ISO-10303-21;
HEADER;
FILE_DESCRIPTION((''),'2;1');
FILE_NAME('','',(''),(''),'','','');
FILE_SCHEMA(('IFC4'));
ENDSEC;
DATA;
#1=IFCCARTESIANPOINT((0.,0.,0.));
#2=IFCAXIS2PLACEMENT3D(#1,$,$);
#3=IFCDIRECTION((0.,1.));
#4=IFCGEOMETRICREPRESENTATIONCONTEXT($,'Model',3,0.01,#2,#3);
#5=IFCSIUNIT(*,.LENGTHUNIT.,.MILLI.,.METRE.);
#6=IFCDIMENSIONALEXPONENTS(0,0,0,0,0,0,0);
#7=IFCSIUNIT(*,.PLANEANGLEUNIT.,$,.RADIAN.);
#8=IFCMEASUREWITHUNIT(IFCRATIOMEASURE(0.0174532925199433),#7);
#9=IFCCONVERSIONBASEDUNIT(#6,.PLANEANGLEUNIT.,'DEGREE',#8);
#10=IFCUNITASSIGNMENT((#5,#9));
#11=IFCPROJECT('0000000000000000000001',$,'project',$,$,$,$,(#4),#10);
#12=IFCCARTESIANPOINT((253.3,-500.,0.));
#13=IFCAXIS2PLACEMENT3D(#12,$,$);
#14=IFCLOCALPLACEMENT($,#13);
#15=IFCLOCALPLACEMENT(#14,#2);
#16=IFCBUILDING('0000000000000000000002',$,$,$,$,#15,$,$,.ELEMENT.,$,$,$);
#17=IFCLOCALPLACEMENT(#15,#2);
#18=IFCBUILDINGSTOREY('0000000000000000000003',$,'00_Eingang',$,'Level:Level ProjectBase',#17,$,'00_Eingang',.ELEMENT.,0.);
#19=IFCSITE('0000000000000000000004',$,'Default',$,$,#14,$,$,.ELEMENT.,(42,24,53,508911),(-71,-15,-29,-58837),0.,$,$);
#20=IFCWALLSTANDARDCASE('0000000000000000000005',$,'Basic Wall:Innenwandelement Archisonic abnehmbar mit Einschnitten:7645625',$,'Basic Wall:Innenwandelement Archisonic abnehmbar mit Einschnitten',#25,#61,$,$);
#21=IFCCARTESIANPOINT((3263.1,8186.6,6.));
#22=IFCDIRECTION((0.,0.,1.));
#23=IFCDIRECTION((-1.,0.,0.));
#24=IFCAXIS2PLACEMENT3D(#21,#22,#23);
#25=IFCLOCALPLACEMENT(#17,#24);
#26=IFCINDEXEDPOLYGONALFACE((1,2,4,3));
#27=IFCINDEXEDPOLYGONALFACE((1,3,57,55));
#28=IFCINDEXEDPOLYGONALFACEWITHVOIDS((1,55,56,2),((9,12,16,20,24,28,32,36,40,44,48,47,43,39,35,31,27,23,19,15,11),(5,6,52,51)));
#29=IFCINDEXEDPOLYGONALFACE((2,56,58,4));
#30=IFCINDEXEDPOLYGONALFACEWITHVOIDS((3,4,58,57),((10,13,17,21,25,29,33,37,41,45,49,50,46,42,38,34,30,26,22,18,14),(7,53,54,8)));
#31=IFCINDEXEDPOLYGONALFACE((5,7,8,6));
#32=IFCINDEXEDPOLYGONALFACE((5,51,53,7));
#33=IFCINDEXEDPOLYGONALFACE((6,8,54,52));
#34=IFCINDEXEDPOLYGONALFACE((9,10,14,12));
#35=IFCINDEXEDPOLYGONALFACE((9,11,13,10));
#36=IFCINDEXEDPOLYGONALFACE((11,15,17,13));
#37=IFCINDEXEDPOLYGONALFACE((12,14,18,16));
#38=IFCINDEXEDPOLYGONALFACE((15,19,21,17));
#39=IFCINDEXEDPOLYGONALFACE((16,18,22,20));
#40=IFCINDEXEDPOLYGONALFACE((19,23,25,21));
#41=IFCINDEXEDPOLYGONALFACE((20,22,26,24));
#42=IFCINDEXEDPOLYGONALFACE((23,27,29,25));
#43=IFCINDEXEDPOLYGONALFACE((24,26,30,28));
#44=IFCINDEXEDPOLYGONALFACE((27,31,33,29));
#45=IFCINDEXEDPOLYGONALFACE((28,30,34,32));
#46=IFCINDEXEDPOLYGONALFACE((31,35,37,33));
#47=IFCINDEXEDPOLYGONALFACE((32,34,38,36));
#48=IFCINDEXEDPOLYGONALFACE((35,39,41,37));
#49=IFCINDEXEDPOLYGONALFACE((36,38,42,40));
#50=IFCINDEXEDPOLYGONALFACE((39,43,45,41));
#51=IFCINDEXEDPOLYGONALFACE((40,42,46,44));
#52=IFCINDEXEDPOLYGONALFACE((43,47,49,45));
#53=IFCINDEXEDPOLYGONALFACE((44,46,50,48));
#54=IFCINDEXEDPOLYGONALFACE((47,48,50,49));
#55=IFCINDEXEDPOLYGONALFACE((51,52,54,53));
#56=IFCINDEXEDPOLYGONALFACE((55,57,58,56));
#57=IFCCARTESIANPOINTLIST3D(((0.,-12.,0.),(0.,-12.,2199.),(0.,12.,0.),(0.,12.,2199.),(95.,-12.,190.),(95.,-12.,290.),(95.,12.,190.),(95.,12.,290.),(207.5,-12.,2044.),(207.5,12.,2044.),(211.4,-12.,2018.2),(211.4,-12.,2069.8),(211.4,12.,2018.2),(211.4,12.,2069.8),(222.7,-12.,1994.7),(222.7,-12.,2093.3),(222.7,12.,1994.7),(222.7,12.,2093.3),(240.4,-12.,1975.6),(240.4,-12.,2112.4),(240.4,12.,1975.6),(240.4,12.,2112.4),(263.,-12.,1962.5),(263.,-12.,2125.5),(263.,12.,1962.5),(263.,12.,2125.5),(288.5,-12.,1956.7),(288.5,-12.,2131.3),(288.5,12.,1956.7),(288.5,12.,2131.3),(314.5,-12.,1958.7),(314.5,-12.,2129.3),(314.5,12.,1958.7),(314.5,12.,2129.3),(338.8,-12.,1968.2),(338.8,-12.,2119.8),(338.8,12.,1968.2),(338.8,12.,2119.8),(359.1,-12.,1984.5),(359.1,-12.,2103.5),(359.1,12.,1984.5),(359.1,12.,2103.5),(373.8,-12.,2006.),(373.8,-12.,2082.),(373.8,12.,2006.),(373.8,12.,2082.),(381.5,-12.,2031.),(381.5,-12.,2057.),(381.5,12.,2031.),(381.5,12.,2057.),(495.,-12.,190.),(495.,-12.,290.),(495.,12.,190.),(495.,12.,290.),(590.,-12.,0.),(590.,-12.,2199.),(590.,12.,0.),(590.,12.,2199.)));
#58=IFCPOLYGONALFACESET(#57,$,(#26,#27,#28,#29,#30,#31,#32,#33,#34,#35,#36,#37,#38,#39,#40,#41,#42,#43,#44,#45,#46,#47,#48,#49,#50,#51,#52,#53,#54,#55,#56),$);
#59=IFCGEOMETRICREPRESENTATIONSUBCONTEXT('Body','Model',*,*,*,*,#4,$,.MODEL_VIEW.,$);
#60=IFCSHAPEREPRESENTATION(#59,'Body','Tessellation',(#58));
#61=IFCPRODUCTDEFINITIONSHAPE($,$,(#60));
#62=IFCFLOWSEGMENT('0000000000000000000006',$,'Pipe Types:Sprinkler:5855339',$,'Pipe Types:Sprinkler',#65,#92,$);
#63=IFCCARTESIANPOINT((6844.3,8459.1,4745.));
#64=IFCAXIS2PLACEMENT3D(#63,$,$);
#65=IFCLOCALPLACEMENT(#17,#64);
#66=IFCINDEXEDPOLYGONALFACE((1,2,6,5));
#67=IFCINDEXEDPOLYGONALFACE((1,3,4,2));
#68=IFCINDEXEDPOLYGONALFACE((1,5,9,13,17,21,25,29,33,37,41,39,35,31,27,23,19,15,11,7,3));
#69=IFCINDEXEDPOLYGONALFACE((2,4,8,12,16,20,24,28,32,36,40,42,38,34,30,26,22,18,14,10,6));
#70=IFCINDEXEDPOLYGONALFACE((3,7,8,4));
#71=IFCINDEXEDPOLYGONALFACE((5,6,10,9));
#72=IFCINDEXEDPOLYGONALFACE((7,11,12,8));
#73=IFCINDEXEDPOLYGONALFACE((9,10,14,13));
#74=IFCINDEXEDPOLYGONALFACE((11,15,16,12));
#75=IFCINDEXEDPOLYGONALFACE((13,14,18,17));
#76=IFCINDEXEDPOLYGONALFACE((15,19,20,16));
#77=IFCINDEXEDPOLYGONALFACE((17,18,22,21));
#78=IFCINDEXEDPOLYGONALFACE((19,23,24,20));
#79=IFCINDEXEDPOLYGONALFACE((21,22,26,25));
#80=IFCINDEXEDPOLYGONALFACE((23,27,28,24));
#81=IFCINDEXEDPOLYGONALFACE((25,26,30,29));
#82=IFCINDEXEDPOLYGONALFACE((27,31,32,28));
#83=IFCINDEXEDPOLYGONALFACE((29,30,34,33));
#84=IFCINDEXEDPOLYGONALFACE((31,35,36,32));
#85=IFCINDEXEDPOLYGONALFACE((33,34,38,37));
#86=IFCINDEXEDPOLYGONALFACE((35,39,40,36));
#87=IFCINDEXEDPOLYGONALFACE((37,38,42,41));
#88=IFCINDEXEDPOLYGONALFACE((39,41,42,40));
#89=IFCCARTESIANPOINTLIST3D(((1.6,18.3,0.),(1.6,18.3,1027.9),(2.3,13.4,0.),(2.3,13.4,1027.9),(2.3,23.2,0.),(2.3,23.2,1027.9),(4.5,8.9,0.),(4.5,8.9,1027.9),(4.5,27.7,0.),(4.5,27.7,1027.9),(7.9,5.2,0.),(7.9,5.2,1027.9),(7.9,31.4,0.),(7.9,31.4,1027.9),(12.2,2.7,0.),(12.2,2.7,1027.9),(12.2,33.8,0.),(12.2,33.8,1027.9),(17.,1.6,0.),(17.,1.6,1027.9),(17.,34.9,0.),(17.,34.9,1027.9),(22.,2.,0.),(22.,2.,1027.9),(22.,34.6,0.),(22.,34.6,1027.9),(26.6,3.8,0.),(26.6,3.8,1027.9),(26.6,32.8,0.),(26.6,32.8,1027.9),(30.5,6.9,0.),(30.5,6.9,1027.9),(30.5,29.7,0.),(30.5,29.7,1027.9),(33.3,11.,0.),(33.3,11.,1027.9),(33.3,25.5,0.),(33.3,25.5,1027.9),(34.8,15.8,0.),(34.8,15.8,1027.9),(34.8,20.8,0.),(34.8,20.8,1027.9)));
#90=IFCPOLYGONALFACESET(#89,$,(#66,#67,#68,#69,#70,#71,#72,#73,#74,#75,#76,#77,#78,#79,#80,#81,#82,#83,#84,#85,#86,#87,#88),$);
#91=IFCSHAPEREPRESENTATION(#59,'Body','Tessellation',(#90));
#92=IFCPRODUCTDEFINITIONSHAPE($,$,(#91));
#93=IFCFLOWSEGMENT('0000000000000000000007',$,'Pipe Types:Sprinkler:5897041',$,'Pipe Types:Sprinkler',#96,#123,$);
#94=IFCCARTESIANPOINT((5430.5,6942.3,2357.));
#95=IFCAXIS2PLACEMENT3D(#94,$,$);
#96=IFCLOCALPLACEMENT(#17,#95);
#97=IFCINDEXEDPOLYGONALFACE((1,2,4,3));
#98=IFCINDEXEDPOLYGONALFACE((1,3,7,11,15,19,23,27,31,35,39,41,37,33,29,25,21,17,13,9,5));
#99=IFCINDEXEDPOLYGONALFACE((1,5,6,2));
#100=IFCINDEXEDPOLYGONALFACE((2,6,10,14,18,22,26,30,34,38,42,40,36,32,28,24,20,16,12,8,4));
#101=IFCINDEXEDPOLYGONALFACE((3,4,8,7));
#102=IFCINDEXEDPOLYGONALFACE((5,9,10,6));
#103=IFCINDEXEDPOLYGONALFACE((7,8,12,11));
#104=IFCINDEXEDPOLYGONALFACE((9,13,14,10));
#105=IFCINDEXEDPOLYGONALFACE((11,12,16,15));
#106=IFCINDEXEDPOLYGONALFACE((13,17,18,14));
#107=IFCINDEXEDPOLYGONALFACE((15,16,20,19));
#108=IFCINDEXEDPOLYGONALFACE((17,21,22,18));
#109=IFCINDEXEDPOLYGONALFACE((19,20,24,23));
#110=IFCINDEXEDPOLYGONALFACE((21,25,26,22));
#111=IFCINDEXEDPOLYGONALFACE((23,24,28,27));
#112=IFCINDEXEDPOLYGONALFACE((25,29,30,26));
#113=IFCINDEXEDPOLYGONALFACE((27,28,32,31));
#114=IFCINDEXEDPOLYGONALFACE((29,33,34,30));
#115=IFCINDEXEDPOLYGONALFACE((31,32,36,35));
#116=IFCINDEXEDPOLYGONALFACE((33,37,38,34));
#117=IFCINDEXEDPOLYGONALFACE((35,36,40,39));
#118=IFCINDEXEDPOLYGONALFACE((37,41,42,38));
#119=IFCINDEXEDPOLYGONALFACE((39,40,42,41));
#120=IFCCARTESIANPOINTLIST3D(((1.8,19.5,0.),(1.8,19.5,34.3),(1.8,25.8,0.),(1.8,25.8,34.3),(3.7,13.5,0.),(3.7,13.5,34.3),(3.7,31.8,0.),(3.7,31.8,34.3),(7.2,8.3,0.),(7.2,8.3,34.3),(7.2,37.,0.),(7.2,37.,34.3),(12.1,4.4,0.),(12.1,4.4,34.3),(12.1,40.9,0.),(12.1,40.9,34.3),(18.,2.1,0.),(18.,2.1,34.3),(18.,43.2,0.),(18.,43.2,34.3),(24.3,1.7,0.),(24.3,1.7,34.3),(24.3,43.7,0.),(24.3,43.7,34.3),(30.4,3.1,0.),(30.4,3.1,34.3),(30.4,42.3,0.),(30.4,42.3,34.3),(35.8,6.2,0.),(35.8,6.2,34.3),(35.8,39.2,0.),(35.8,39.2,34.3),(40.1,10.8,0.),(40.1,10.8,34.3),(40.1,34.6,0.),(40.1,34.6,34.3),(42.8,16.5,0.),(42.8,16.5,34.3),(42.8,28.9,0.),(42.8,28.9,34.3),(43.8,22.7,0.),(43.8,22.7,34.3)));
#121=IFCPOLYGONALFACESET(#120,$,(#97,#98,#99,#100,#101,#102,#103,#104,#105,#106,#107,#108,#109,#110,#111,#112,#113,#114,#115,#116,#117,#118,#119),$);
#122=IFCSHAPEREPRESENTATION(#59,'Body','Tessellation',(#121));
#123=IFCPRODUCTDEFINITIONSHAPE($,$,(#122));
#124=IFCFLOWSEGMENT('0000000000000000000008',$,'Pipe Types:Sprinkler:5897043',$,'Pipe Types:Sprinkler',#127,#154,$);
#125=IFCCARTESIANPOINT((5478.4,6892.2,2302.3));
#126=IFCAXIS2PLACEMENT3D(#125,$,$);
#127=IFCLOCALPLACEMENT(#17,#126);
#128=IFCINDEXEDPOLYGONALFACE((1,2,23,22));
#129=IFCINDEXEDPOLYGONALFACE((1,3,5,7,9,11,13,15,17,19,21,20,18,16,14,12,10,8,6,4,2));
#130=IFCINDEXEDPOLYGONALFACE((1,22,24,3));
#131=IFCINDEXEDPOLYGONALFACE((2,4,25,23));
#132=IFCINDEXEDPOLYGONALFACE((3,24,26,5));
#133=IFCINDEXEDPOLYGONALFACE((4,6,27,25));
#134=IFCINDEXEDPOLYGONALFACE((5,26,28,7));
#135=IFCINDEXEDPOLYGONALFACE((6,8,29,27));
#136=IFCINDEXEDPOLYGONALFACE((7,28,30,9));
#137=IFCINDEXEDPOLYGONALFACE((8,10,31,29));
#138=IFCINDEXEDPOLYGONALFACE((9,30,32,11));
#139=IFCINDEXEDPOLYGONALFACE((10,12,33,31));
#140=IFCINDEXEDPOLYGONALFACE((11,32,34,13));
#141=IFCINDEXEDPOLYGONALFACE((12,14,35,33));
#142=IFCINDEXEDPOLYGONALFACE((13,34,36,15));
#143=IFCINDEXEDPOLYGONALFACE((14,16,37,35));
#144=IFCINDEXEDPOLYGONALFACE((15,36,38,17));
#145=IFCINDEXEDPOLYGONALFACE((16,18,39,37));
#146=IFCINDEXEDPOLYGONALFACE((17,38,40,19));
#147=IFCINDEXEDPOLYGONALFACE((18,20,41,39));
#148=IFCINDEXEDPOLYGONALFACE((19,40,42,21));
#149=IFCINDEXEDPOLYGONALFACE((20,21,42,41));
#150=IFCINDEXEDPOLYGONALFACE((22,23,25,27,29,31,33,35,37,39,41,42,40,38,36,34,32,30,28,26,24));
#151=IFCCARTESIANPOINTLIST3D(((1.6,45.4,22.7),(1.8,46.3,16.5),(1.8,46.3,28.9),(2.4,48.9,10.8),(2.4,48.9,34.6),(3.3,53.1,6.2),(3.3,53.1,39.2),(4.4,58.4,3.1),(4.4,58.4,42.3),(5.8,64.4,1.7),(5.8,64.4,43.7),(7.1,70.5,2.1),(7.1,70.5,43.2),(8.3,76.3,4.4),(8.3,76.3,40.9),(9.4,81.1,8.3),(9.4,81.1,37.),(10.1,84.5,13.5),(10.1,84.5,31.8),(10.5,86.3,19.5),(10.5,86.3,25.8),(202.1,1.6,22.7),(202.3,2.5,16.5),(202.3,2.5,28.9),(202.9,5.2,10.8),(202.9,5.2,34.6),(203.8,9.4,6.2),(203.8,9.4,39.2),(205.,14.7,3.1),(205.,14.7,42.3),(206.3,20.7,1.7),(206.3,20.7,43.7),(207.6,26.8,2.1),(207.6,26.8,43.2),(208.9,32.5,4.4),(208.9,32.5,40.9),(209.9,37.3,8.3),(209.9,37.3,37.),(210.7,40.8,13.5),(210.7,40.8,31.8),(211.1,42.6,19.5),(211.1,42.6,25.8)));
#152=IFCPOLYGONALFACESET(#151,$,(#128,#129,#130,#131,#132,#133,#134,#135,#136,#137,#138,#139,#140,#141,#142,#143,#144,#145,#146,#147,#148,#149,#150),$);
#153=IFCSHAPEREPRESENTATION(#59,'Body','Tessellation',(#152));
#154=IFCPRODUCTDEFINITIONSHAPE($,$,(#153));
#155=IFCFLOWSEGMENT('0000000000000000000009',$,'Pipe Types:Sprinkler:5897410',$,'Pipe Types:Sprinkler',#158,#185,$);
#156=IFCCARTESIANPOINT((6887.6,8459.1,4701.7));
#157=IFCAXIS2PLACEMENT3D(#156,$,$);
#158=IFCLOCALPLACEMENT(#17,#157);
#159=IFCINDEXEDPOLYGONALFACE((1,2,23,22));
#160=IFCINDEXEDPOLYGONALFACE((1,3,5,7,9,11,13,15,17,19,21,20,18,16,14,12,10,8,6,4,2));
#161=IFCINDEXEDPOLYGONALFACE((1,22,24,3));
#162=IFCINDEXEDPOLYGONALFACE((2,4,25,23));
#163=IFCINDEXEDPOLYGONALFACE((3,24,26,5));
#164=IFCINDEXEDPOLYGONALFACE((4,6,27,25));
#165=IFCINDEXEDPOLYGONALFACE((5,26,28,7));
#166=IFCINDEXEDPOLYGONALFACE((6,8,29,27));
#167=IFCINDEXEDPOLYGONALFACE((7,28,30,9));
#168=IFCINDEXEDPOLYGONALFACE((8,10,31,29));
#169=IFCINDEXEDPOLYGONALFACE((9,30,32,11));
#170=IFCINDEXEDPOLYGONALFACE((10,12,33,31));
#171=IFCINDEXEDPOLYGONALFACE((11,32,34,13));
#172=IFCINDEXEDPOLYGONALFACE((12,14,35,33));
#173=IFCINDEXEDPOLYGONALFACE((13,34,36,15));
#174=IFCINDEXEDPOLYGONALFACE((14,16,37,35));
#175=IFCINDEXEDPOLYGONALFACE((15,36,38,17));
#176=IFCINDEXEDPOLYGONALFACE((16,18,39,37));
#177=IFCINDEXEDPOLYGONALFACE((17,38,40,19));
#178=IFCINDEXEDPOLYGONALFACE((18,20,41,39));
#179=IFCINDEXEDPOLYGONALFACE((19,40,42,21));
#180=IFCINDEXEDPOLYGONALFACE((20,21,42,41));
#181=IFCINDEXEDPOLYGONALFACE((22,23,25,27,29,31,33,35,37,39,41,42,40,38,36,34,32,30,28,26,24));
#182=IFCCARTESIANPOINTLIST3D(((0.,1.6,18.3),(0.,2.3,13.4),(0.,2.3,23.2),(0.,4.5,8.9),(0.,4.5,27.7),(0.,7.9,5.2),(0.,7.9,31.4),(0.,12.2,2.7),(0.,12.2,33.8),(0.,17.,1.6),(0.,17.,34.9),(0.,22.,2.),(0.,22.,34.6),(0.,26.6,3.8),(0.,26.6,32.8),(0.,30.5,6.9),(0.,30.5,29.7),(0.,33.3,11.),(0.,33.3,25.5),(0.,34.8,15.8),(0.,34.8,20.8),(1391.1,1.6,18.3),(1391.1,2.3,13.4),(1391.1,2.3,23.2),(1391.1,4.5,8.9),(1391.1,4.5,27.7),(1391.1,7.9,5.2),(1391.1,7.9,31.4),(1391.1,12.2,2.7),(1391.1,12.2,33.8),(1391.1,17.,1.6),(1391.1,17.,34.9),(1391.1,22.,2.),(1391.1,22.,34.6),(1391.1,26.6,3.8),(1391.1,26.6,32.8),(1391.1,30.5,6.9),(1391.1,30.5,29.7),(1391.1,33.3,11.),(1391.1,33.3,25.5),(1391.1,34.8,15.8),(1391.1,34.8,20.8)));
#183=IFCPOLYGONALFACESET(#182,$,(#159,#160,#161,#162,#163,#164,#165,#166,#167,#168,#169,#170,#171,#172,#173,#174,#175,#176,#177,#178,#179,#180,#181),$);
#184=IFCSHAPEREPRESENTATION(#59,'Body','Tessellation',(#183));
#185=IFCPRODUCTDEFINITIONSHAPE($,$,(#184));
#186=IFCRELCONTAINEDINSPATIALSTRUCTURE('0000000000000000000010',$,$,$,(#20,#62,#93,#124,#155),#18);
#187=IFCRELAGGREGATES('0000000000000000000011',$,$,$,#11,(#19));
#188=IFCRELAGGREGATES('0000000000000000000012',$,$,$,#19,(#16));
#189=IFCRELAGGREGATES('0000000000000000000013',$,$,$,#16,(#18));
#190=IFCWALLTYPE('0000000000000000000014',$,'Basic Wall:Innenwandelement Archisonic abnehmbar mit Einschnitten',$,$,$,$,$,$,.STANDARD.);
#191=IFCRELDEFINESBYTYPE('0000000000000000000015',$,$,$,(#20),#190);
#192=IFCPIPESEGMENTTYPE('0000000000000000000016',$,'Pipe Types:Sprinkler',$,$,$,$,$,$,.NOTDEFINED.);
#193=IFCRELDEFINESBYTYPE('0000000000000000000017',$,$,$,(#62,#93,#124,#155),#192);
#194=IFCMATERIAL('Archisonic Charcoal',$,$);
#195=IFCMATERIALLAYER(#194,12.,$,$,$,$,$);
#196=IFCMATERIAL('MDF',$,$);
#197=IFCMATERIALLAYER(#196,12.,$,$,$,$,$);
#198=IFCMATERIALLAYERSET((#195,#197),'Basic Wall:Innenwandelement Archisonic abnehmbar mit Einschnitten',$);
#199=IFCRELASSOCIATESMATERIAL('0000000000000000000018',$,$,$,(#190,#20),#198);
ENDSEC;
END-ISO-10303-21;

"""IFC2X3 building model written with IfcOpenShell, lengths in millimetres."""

from ifc_helpers import new_model, entity, si_unit, converted_unit, direction, frame, frame_2d, origin, origin_2d_with_axis, place, context, subcontext, project, spatial, rectangle, circle, extrude, material, layer, layer_set, layer_usage, type_object, element, save


model = new_model("IFC2X3")

# Units and contexts
model_context = context("Model", 3, precision=0.01, world=origin(), true_north=direction((0.0, 1.0)))
body_context = subcontext(model_context, "Body", "Model", "MODEL_VIEW")
ifc_project = project(units=[si_unit("LENGTHUNIT", "METRE", prefix="MILLI"), converted_unit("PLANEANGLEUNIT", "DEGREE", entity("IfcRatioMeasure", 0.0174532925199433), si_unit("PLANEANGLEUNIT", "RADIAN"), dimensions=[0, 0, 0, 0, 0, 0, 0])], contexts=[model_context])

# Site, building, storey
site_placement = place(None, frame((253.3, -500.0, 0.0)))
site = spatial("IfcSite", under=ifc_project, at=site_placement, Name="Default", CompositionType="ELEMENT", RefLatitude=(42, 24, 53, 508911), RefLongitude=(-71, -15, -29, -58837), RefElevation=0.0)
building_placement = place(site_placement, origin())
building = spatial("IfcBuilding", under=site, at=building_placement, CompositionType="ELEMENT")
storey_placement = place(building_placement, origin())
storey = spatial("IfcBuildingStorey", under=building, at=storey_placement, Name="00_Eingang", ObjectType="Level:Level ProjectBase", LongName="00_Eingang", CompositionType="ELEMENT", Elevation=0.0)

# Shared definitions
ifc_material_1 = material(Name="Archisonic Charcoal")
ifc_material_2 = material(Name="MDF")

# Wall, openings
ifc_layer_1 = layer(ifc_material_1, 12.0)
ifc_layer_2 = layer(ifc_material_2, 12.0)
ifc_layer_set_1 = layer_set([ifc_layer_1, ifc_layer_2], Name="Basic Wall:Innenwandelement Archisonic abnehmbar mit Einschnitten")
ifc_layer_usage_1 = layer_usage(ifc_layer_set_1, "AXIS2", "NEGATIVE", 12.0)
wall_type_1 = type_object("IfcWallType", Name="Basic Wall:Innenwandelement Archisonic abnehmbar mit Einschnitten", PredefinedType="STANDARD", material=ifc_layer_set_1)
wall_1_placement = place(storey_placement, frame((3263.1, 8186.6, 6.0), z_axis=(0.0, 0.0, 1.0), x_axis=(-1.0, 0.0, 0.0)))
wall_1 = element("IfcWallStandardCase", 1, at=wall_1_placement, inside=storey, type_object=wall_type_1, material=ifc_layer_usage_1, Name="Basic Wall:Innenwandelement Archisonic abnehmbar mit Einschnitten:7645625", ObjectType="Basic Wall:Innenwandelement Archisonic abnehmbar mit Einschnitten", context=body_context, shape_type="SweptSolid", body=[
    extrude(rectangle(XDim=590.0, YDim=24.0, at=frame_2d((295.0, 0.0), x_axis=(-1.0, 0.0))), origin(), (0.0, 0.0, 1.0), 2199.0),
])
opening_1_placement = place(wall_1_placement, frame((384.1, 46.7, 1954.9)))
element("IfcOpeningElement", 2, at=opening_1_placement, cuts=wall_1, ObjectType="Opening", context=body_context, shape_type="SweptSolid", body=[
    extrude(circle(Radius=87.5, at=origin_2d_with_axis()), frame((-89.1, -336.7, 89.1), z_axis=(0.0, 1.0, 0.0), x_axis=(-1.0, 0.0, 0.0)), (0.0, 0.0, 1.0), 336.7),
])
opening_2_placement = place(wall_1_placement, frame((495.0, 70.0, 190.0)))
element("IfcOpeningElement", 3, at=opening_2_placement, cuts=wall_1, ObjectType="Opening", context=body_context, shape_type="SweptSolid", body=[
    extrude(rectangle(XDim=100.0, YDim=400.0, at=frame_2d((0.0, 0.0), x_axis=(0.0, 1.0))), frame((-200.0, -200.0, 50.0), z_axis=(0.0, 1.0, 0.0), x_axis=(-1.0, 0.0, 0.0)), (0.0, 0.0, 1.0), 200.0),
])

# Flow segments
pipe_segment_type = type_object("IfcPipeSegmentType", Name="Pipe Types:Sprinkler", PredefinedType="NOTDEFINED")
flow_segment_1_placement = place(storey_placement, frame((6844.3, 8459.1, 4745.0)))
element("IfcFlowSegment", 4, at=flow_segment_1_placement, inside=storey, type_object=pipe_segment_type, Name="Pipe Types:Sprinkler:5855339", ObjectType="Pipe Types:Sprinkler", context=body_context, shape_type="SweptSolid", body=[
    extrude(circle(Radius=16.7, at=origin_2d_with_axis()), frame((18.3, 18.3, 0.0), z_axis=(0.0, 0.0, 1.0), x_axis=(-1.0, 0.0, 0.0)), (0.0, 0.0, 1.0), 1027.9),
])
flow_segment_2_placement = place(storey_placement, frame((5430.5, 6942.3, 2357.0)))
element("IfcFlowSegment", 5, at=flow_segment_2_placement, inside=storey, type_object=pipe_segment_type, Name="Pipe Types:Sprinkler:5897041", ObjectType="Pipe Types:Sprinkler", context=body_context, shape_type="SweptSolid", body=[
    extrude(circle(Radius=21.1, at=origin_2d_with_axis()), frame((22.7, 22.7, 0.0)), (0.0, 0.0, 1.0), 34.3),
])
flow_segment_3_placement = place(storey_placement, frame((5478.4, 6892.2, 2302.3)))
element("IfcFlowSegment", 6, at=flow_segment_3_placement, inside=storey, type_object=pipe_segment_type, Name="Pipe Types:Sprinkler:5897043", ObjectType="Pipe Types:Sprinkler", context=body_context, shape_type="SweptSolid", body=[
    extrude(circle(Radius=21.1, at=frame_2d((0.0, 0.0), x_axis=(1.0, 0.0))), frame((6.1, 66.0, 22.7), z_axis=(0.977009, -0.213196, 0.0), x_axis=(-0.213196, -0.977009, 0.0)), (0.0, 0.0, 1.0), 205.3),
])
flow_segment_4_placement = place(storey_placement, frame((6887.6, 8459.1, 4701.7)))
element("IfcFlowSegment", 7, at=flow_segment_4_placement, inside=storey, type_object=pipe_segment_type, Name="Pipe Types:Sprinkler:5897410", ObjectType="Pipe Types:Sprinkler", context=body_context, shape_type="SweptSolid", body=[
    extrude(circle(Radius=16.7, at=origin_2d_with_axis()), frame((0.0, 18.3, 18.3), z_axis=(1.0, 0.0, 0.0), x_axis=(0.0, -1.0, 0.0)), (0.0, 0.0, 1.0), 1391.1),
])

save(model, "model.ifc")
